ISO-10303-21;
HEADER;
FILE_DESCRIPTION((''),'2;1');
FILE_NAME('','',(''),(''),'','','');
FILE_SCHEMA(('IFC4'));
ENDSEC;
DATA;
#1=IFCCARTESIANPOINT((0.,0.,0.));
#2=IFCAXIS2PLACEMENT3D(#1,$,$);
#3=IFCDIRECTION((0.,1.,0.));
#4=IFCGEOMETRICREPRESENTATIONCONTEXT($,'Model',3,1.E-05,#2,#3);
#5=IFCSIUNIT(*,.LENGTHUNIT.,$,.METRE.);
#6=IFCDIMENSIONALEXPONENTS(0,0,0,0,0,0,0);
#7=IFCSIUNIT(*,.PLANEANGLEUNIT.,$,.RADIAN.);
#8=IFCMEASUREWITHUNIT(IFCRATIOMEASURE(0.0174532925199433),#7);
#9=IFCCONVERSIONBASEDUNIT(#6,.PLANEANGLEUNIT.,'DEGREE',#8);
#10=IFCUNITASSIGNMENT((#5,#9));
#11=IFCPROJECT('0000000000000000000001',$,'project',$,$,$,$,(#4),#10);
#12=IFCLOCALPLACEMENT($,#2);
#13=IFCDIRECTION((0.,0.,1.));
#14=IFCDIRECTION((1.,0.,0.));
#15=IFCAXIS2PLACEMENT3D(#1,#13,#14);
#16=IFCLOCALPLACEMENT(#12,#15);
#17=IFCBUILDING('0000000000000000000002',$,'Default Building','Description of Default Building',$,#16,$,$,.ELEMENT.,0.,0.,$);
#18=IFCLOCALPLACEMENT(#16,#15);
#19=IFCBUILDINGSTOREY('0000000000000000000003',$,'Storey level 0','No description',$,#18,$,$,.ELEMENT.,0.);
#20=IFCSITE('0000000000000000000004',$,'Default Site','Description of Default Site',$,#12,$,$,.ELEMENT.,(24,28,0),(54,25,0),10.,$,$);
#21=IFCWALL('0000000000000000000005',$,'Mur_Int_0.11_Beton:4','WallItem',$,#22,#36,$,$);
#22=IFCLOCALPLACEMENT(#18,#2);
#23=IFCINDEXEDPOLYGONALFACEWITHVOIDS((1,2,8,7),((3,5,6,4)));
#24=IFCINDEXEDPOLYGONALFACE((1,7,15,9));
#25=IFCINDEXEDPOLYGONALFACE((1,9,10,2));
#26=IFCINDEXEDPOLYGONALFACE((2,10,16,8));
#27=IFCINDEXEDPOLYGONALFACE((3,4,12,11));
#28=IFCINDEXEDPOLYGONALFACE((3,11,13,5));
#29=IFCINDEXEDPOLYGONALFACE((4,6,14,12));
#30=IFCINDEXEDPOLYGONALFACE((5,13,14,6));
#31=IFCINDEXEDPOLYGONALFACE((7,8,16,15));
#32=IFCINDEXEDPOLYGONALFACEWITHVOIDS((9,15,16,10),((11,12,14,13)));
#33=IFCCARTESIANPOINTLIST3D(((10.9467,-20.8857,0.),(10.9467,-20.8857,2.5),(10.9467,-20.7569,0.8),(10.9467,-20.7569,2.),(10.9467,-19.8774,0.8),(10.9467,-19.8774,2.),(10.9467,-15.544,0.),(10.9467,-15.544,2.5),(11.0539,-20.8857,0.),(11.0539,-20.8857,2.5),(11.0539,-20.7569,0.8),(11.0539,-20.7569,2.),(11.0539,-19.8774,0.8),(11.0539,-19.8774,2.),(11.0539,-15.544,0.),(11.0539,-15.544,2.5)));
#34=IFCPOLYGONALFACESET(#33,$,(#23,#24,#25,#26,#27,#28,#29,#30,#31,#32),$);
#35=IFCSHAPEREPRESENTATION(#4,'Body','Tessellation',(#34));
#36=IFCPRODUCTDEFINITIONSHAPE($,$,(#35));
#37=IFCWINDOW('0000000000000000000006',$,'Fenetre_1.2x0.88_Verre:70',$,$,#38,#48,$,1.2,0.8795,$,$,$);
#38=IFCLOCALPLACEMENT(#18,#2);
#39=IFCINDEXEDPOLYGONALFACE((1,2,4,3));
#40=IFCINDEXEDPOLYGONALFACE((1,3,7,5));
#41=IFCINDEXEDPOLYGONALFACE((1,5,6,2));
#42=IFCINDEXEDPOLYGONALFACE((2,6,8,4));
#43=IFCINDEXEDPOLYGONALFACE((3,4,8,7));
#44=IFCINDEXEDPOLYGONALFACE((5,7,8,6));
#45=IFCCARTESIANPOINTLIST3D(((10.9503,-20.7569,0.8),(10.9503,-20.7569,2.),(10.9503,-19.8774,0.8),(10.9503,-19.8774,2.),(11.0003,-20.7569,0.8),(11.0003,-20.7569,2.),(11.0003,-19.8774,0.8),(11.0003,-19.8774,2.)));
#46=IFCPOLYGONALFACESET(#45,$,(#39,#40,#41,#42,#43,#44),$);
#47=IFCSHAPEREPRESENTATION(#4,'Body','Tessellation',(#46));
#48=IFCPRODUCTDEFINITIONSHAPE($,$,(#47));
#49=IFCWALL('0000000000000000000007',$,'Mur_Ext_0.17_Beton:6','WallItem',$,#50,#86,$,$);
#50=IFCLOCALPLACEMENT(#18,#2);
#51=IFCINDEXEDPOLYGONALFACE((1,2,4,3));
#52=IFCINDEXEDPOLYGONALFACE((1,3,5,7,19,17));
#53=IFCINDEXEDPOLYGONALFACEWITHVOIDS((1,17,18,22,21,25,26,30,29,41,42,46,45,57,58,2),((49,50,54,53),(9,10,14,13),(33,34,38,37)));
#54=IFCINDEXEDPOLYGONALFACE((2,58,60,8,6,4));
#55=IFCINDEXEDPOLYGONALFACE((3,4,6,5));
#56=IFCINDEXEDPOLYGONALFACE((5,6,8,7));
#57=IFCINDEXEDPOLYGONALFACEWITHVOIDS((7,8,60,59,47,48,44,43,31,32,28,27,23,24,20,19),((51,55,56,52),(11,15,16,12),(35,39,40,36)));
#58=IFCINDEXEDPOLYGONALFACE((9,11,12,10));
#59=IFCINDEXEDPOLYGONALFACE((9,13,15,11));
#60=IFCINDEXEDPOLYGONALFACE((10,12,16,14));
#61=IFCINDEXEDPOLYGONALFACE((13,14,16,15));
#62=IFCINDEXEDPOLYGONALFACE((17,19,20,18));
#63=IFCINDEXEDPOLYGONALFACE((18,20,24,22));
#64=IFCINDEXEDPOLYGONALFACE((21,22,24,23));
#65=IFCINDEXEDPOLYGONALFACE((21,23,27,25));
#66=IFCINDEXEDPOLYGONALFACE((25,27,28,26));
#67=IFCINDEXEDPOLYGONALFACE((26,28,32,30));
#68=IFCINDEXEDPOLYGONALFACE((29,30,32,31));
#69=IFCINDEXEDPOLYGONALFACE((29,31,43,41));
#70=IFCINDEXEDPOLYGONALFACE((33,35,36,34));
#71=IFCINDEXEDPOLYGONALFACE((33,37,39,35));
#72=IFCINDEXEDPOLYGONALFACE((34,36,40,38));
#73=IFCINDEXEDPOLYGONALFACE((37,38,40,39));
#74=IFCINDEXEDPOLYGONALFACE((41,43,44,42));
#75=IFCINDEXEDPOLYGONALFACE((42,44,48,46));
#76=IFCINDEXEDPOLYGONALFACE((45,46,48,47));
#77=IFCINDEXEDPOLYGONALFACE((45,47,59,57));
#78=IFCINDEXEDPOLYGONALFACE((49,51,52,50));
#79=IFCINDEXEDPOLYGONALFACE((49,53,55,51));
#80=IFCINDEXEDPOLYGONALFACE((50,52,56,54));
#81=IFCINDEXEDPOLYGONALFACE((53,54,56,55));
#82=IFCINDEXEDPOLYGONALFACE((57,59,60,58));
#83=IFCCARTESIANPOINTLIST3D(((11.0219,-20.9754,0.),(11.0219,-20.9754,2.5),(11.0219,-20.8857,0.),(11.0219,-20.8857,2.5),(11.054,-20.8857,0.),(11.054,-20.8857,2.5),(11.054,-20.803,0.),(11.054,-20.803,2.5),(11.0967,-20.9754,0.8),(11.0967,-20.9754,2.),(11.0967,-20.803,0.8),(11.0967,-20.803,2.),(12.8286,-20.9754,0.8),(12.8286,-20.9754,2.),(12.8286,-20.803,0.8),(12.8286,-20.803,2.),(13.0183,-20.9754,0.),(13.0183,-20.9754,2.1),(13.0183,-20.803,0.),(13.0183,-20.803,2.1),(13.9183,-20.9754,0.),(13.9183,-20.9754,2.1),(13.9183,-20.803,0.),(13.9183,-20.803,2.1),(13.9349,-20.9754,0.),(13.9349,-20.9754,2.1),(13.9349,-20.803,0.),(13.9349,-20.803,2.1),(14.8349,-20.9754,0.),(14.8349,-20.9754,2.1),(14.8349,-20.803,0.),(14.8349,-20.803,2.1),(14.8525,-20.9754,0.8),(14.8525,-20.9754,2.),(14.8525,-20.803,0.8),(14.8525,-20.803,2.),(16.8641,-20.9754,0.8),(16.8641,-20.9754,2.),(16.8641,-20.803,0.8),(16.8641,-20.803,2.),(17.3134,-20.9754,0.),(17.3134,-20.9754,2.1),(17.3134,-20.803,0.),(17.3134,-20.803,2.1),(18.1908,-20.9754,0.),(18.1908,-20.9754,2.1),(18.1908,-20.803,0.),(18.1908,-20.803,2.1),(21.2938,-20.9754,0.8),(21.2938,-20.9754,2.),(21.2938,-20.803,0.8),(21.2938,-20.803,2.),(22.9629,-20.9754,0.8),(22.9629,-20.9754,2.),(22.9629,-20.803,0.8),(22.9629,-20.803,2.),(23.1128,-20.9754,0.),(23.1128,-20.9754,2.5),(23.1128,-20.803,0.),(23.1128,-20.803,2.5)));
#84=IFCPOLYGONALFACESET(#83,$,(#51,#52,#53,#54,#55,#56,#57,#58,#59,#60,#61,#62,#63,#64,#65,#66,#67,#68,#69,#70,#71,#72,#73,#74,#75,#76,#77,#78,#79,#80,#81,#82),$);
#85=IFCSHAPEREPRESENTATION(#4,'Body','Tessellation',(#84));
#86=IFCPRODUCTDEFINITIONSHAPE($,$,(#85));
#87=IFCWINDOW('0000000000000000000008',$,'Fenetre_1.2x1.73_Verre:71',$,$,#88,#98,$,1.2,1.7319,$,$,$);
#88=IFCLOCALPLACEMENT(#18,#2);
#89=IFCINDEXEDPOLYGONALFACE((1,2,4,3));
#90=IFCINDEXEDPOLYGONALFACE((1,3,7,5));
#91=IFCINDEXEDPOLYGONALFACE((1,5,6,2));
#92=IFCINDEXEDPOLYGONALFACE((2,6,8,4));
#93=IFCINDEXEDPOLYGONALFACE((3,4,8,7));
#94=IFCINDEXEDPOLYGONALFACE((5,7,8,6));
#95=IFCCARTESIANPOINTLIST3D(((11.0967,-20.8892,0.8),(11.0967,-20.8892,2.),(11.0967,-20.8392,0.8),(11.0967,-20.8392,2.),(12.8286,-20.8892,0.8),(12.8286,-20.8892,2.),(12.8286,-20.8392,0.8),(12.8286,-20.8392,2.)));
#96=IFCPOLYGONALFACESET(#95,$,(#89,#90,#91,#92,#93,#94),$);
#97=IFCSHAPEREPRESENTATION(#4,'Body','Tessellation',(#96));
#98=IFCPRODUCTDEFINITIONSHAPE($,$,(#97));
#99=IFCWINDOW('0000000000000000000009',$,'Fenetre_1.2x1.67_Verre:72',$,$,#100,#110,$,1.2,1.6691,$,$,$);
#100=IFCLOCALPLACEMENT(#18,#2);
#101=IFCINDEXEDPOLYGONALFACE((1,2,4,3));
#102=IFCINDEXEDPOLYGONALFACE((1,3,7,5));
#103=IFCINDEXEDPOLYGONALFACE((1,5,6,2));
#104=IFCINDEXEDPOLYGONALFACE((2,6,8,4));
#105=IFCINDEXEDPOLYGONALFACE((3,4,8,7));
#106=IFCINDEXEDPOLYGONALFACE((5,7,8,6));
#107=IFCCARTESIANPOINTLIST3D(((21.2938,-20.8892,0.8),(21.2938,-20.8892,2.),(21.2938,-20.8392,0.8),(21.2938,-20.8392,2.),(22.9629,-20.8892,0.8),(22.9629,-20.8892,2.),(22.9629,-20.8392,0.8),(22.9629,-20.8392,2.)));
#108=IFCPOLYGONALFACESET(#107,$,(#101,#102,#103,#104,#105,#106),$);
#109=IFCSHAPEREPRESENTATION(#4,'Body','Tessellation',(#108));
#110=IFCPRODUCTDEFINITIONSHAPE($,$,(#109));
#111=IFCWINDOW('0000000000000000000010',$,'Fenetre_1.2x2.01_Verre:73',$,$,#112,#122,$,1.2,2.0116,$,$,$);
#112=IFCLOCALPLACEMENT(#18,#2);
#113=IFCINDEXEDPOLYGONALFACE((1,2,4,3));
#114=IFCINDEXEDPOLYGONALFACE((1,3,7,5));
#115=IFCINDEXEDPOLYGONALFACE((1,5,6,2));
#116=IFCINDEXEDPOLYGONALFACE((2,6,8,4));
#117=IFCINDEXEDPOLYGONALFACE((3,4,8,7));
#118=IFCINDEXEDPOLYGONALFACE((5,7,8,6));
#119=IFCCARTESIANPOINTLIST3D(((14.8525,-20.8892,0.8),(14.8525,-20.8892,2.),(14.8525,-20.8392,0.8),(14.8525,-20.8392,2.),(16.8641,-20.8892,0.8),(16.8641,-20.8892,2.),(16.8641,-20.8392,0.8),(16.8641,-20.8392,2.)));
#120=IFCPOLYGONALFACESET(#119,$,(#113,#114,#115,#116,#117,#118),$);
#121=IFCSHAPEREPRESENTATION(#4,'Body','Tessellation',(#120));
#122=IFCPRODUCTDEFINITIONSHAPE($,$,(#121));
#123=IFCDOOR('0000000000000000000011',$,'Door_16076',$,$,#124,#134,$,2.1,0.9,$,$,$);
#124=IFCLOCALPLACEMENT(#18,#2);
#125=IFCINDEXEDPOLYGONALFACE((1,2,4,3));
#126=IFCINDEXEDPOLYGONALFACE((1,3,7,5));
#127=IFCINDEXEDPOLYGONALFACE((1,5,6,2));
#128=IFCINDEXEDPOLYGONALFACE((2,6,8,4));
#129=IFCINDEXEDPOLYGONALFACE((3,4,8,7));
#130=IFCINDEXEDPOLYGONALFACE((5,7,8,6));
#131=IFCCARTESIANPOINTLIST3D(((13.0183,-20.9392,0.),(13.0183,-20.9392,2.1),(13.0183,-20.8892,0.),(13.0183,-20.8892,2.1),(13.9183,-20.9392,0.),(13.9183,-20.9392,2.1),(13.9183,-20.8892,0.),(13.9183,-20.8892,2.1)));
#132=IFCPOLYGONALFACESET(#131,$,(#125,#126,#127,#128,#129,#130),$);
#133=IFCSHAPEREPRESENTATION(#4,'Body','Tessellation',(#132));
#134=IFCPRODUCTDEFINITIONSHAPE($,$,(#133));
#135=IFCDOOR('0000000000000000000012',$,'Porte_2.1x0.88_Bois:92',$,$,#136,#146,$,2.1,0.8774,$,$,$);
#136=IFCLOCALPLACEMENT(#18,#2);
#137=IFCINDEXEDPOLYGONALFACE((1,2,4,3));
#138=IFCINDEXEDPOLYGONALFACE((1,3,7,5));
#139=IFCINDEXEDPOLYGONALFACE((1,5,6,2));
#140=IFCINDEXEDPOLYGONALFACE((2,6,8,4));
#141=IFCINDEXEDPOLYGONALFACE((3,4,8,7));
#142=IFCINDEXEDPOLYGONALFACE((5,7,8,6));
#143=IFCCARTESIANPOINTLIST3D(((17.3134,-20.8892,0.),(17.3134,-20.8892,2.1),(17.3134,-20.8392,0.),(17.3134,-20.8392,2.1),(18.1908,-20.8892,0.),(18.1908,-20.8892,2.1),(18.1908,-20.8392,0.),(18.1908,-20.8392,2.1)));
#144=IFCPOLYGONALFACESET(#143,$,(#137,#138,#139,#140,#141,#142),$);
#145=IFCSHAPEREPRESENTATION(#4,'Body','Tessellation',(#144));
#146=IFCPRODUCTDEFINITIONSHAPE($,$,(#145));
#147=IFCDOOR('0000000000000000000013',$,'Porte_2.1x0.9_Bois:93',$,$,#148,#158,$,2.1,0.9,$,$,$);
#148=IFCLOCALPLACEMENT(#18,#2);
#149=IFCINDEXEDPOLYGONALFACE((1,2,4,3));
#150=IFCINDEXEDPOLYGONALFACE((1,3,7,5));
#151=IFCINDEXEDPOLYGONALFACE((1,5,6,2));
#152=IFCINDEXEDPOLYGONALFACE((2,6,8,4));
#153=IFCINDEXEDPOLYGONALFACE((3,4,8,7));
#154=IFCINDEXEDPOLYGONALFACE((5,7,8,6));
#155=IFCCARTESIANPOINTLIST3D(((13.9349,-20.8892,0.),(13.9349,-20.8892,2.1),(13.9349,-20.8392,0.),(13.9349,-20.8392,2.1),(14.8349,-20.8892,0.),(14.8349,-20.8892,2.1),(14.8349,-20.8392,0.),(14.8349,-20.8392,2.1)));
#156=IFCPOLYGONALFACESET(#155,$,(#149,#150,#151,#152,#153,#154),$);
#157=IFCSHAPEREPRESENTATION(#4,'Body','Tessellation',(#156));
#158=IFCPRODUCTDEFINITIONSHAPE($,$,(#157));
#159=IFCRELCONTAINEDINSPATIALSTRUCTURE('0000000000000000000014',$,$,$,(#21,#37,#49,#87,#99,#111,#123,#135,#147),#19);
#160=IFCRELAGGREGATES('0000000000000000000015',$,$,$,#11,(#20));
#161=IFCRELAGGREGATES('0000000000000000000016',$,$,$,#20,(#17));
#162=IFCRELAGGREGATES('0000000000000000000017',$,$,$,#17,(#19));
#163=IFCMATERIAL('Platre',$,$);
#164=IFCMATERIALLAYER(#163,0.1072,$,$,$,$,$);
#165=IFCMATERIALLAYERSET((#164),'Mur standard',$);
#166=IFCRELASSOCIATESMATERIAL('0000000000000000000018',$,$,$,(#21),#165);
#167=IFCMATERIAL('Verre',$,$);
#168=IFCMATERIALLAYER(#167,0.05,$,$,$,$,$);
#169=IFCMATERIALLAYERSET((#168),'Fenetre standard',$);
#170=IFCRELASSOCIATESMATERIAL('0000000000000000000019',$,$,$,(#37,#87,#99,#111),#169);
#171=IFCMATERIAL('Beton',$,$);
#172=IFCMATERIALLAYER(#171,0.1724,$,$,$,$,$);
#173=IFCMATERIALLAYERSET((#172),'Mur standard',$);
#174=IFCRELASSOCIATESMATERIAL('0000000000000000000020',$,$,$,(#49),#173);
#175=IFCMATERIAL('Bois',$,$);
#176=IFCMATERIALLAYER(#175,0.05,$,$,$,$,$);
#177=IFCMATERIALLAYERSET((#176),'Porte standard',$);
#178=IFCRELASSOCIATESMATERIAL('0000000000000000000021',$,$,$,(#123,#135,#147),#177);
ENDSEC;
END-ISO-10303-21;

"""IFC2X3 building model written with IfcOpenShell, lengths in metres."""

from ifc_helpers import new_model, entity, si_unit, converted_unit, direction, frame, origin, origin_with_axes, place, context, project, spatial, polyline, outline, extrude, material, layer, layer_set, layer_usage, element, fill, save


model = new_model("IFC2X3")

# Units and contexts
model_context = context("Model", 3, precision=1e-05, world=origin(), true_north=direction((0.0, 1.0, 0.0)))
ifc_project = project(units=[si_unit("LENGTHUNIT", "METRE"), converted_unit("PLANEANGLEUNIT", "DEGREE", entity("IfcRatioMeasure", 0.0174532925199433), si_unit("PLANEANGLEUNIT", "RADIAN"), dimensions=[0, 0, 0, 0, 0, 0, 0])], contexts=[model_context])

# Site, building, storey
site_placement = place(None, origin())
site = spatial("IfcSite", under=ifc_project, at=site_placement, Name="Default Site", Description="Description of Default Site", CompositionType="ELEMENT", RefLatitude=(24, 28, 0), RefLongitude=(54, 25, 0), RefElevation=10.0)
building_placement = place(site_placement, origin_with_axes())
building = spatial("IfcBuilding", under=site, at=building_placement, Name="Default Building", Description="Description of Default Building", CompositionType="ELEMENT", ElevationOfRefHeight=0.0, ElevationOfTerrain=0.0)
storey_placement = place(building_placement, origin_with_axes())
storey = spatial("IfcBuildingStorey", under=building, at=storey_placement, Name="Storey level 0", Description="No description", CompositionType="ELEMENT", Elevation=0.0)

# Wall, opening, window
ifc_material_1 = material(Name="Platre")
ifc_layer_1 = layer(ifc_material_1, 0.1072)
ifc_layer_set_1 = layer_set([ifc_layer_1], Name="Mur standard")
ifc_layer_usage_1 = layer_usage(ifc_layer_set_1, "AXIS2", "NEGATIVE", 0.1072)
wall_1_placement = place(storey_placement, frame((11.0003, -15.544, 0.0), z_axis=(0.0, 0.0, 1.0), x_axis=(0.0, -1.0, 0.0)))
wall_1 = element("IfcWall", 1, at=wall_1_placement, inside=storey, material=ifc_layer_usage_1, Name="Mur_Int_0.11_Beton:4", Description="WallItem", context=model_context, shape_type="SweptSolid", body=[
    extrude(outline(polyline([(0.0, -0.0536), (5.3417, -0.0536), (5.3417, 0.0536), (0.0, 0.0536), (0.0, -0.0536)])), origin(), (0.0, 0.0, 1.0), 2.5),
])
opening_1_placement = place(storey_placement, frame((10.9467, -19.8774, 0.8), z_axis=(0.0, 0.0, 1.0), x_axis=(0.0, -1.0, 0.0)))
opening_1 = element("IfcOpeningElement", 2, at=opening_1_placement, cuts=wall_1, context=model_context, shape_type="SweptSolid", body=[
    extrude(outline(polyline([(0.0, -0.05), (0.8795, -0.05), (0.8795, 0.1572), (0.0, 0.1572), (0.0, -0.05)])), origin(), (0.0, 0.0, 1.0), 1.2),
])
ifc_material_2 = material(Name="Verre")
ifc_layer_2 = layer(ifc_material_2, 0.05)
ifc_layer_set_2 = layer_set([ifc_layer_2], Name="Fenetre standard")
ifc_layer_usage_2 = layer_usage(ifc_layer_set_2, "AXIS2", "NEGATIVE", 0.05)
window_1_placement = place(wall_1_placement, frame((4.3334, 0.0, 0.8), z_axis=(0.0, 0.0, 1.0), x_axis=(1.0, 0.0, 0.0)))
window_1 = element("IfcWindow", 3, at=window_1_placement, inside=storey, material=ifc_layer_usage_2, Name="Fenetre_1.2x0.88_Verre:70", OverallHeight=1.2, OverallWidth=0.8795, context=model_context, shape_type="SweptSolid", body=[
    extrude(outline(polyline([(0.0, 0.0), (0.8795, 0.0), (0.8795, -0.05), (0.0, -0.05), (0.0, 0.0)])), origin(), (0.0, 0.0, 1.0), 1.2),
])
fill(opening_1, window_1)

# Wall, openings, windows, doors
ifc_material_3 = material(Name="Beton")
ifc_layer_3 = layer(ifc_material_3, 0.1724)
ifc_layer_set_3 = layer_set([ifc_layer_3], Name="Mur standard")
ifc_layer_usage_3 = layer_usage(ifc_layer_set_3, "AXIS2", "NEGATIVE", 0.1724)
wall_2_placement = place(storey_placement, frame((11.0219, -20.8892, 0.0), z_axis=(0.0, 0.0, 1.0), x_axis=(1.0, 0.0, 0.0)))
wall_2 = element("IfcWall", 4, at=wall_2_placement, inside=storey, material=ifc_layer_usage_3, Name="Mur_Ext_0.17_Beton:6", Description="WallItem", context=model_context, shape_type="SweptSolid", body=[
    extrude(outline(polyline([(12.0909, -0.0862), (0.0, -0.0862), (0.0, 0.0035), (0.0321, 0.0035), (0.0321, 0.0862), (12.0909, 0.0862), (12.0909, -0.0862)])), origin(), (0.0, 0.0, 1.0), 2.5),
])
opening_2_placement = place(storey_placement, frame((12.8286, -20.803, 0.8), z_axis=(0.0, 0.0, 1.0), x_axis=(-1.0, 0.0, 0.0)))
opening_2 = element("IfcOpeningElement", 5, at=opening_2_placement, cuts=wall_2, context=model_context, shape_type="SweptSolid", body=[
    extrude(outline(polyline([(1.7319, 0.2224), (0.0, 0.2224), (0.0, -0.05), (1.7319, -0.05), (1.7319, 0.2224)])), origin(), (0.0, 0.0, 1.0), 1.2),
])
opening_3_placement = place(storey_placement, frame((22.9629, -20.803, 0.8), z_axis=(0.0, 0.0, 1.0), x_axis=(-1.0, 0.0, 0.0)))
opening_3 = element("IfcOpeningElement", 6, at=opening_3_placement, cuts=wall_2, context=model_context, shape_type="SweptSolid", body=[
    extrude(outline(polyline([(1.6691, 0.2224), (0.0, 0.2224), (0.0, -0.05), (1.6691, -0.05), (1.6691, 0.2224)])), origin(), (0.0, 0.0, 1.0), 1.2),
])
opening_4_placement = place(storey_placement, frame((16.8641, -20.803, 0.8), z_axis=(0.0, 0.0, 1.0), x_axis=(-1.0, 0.0, 0.0)))
opening_4 = element("IfcOpeningElement", 7, at=opening_4_placement, cuts=wall_2, context=model_context, shape_type="SweptSolid", body=[
    extrude(outline(polyline([(2.0116, 0.2224), (0.0, 0.2224), (0.0, -0.05), (2.0116, -0.05), (2.0116, 0.2224)])), origin(), (0.0, 0.0, 1.0), 1.2),
])
opening_5_placement = place(storey_placement, frame((13.0183, -20.9754, 0.0), z_axis=(0.0, 0.0, 1.0), x_axis=(1.0, 0.0, 0.0)))
opening_5 = element("IfcOpeningElement", 8, at=opening_5_placement, cuts=wall_2, context=model_context, shape_type="SweptSolid", body=[
    extrude(outline(polyline([(0.0, -0.05), (0.9, -0.05), (0.9, 0.2224), (0.0, 0.2224), (0.0, -0.05)])), origin(), (0.0, 0.0, 1.0), 2.1),
])
opening_6_placement = place(storey_placement, frame((18.1908, -20.803, 0.0), z_axis=(0.0, 0.0, 1.0), x_axis=(-1.0, 0.0, 0.0)))
opening_6 = element("IfcOpeningElement", 9, at=opening_6_placement, cuts=wall_2, context=model_context, shape_type="SweptSolid", body=[
    extrude(outline(polyline([(0.8774, 0.2224), (0.0, 0.2224), (0.0, -0.05), (0.8774, -0.05), (0.8774, 0.2224)])), origin(), (0.0, 0.0, 1.0), 2.1),
])
opening_7_placement = place(storey_placement, frame((14.8349, -20.9754, 0.0), z_axis=(0.0, 0.0, 1.0), x_axis=(-1.0, 0.0, 0.0)))
opening_7 = element("IfcOpeningElement", 10, at=opening_7_placement, cuts=wall_2, context=model_context, shape_type="SweptSolid", body=[
    extrude(outline(polyline([(0.9, 0.05), (0.0, 0.05), (0.0, -0.2224), (0.9, -0.2224), (0.9, 0.05)])), origin(), (0.0, 0.0, 1.0), 2.1),
])
window_2_placement = place(wall_2_placement, frame((1.8067, 0.0, 0.8), z_axis=(0.0, 0.0, 1.0), x_axis=(-1.0, 0.0, 0.0)))
window_2 = element("IfcWindow", 11, at=window_2_placement, inside=storey, material=ifc_layer_usage_2, Name="Fenetre_1.2x1.73_Verre:71", OverallHeight=1.2, OverallWidth=1.7319, context=model_context, shape_type="SweptSolid", body=[
    extrude(outline(polyline([(0.0, 0.0), (1.7319, 0.0), (1.7319, -0.05), (0.0, -0.05), (0.0, 0.0)])), origin(), (0.0, 0.0, 1.0), 1.2),
])
fill(opening_2, window_2)
window_3_placement = place(wall_2_placement, frame((11.941, 0.0, 0.8), z_axis=(0.0, 0.0, 1.0), x_axis=(-1.0, 0.0, 0.0)))
window_3 = element("IfcWindow", 12, at=window_3_placement, inside=storey, material=ifc_layer_usage_2, Name="Fenetre_1.2x1.67_Verre:72", OverallHeight=1.2, OverallWidth=1.6691, context=model_context, shape_type="SweptSolid", body=[
    extrude(outline(polyline([(0.0, 0.0), (1.6691, 0.0), (1.6691, -0.05), (0.0, -0.05), (0.0, 0.0)])), origin(), (0.0, 0.0, 1.0), 1.2),
])
fill(opening_3, window_3)
window_4_placement = place(wall_2_placement, frame((5.8422, 0.0, 0.8), z_axis=(0.0, 0.0, 1.0), x_axis=(-1.0, 0.0, 0.0)))
window_4 = element("IfcWindow", 13, at=window_4_placement, inside=storey, material=ifc_layer_usage_2, Name="Fenetre_1.2x2.01_Verre:73", OverallHeight=1.2, OverallWidth=2.0116, context=model_context, shape_type="SweptSolid", body=[
    extrude(outline(polyline([(0.0, 0.0), (2.0116, 0.0), (2.0116, -0.05), (0.0, -0.05), (0.0, 0.0)])), origin(), (0.0, 0.0, 1.0), 1.2),
])
fill(opening_4, window_4)
ifc_material_4 = material(Name="Bois")
ifc_layer_4 = layer(ifc_material_4, 0.05)
ifc_layer_set_4 = layer_set([ifc_layer_4], Name="Porte standard")
ifc_layer_usage_4 = layer_usage(ifc_layer_set_4, "AXIS2", "NEGATIVE", 0.05)
door_1_placement = place(wall_2_placement, frame((1.9964, 0.0, 0.0), z_axis=(0.0, 0.0, 1.0), x_axis=(1.0, 0.0, 0.0)))
door_1 = element("IfcDoor", 14, at=door_1_placement, inside=storey, material=ifc_layer_usage_4, Name="Door_16076", OverallHeight=2.1, OverallWidth=0.9, context=model_context, shape_type="SweptSolid", body=[
    extrude(outline(polyline([(0.0, 0.0), (0.9, 0.0), (0.9, -0.05), (0.0, -0.05), (0.0, 0.0)])), origin(), (0.0, 0.0, 1.0), 2.1),
])
fill(opening_5, door_1)
door_2_placement = place(wall_2_placement, frame((7.1689, 0.0, 0.0), z_axis=(0.0, 0.0, 1.0), x_axis=(-1.0, 0.0, 0.0)))
door_2 = element("IfcDoor", 15, at=door_2_placement, inside=storey, material=ifc_layer_usage_4, Name="Porte_2.1x0.88_Bois:92", OverallHeight=2.1, OverallWidth=0.8774, context=model_context, shape_type="SweptSolid", body=[
    extrude(outline(polyline([(0.0, 0.0), (0.8774, 0.0), (0.8774, -0.05), (0.0, -0.05), (0.0, 0.0)])), origin(), (0.0, 0.0, 1.0), 2.1),
])
fill(opening_6, door_2)
door_3_placement = place(wall_2_placement, frame((3.813, 0.0, 0.0), z_axis=(0.0, 0.0, 1.0), x_axis=(-1.0, 0.0, 0.0)))
door_3 = element("IfcDoor", 16, at=door_3_placement, inside=storey, material=ifc_layer_usage_4, Name="Porte_2.1x0.9_Bois:93", OverallHeight=2.1, OverallWidth=0.9, context=model_context, shape_type="SweptSolid", body=[
    extrude(outline(polyline([(0.0, 0.0), (0.9, 0.0), (0.9, -0.05), (0.0, -0.05), (0.0, 0.0)])), origin(), (0.0, 0.0, 1.0), 2.1),
])
fill(opening_7, door_3)

save(model, "model.ifc")
